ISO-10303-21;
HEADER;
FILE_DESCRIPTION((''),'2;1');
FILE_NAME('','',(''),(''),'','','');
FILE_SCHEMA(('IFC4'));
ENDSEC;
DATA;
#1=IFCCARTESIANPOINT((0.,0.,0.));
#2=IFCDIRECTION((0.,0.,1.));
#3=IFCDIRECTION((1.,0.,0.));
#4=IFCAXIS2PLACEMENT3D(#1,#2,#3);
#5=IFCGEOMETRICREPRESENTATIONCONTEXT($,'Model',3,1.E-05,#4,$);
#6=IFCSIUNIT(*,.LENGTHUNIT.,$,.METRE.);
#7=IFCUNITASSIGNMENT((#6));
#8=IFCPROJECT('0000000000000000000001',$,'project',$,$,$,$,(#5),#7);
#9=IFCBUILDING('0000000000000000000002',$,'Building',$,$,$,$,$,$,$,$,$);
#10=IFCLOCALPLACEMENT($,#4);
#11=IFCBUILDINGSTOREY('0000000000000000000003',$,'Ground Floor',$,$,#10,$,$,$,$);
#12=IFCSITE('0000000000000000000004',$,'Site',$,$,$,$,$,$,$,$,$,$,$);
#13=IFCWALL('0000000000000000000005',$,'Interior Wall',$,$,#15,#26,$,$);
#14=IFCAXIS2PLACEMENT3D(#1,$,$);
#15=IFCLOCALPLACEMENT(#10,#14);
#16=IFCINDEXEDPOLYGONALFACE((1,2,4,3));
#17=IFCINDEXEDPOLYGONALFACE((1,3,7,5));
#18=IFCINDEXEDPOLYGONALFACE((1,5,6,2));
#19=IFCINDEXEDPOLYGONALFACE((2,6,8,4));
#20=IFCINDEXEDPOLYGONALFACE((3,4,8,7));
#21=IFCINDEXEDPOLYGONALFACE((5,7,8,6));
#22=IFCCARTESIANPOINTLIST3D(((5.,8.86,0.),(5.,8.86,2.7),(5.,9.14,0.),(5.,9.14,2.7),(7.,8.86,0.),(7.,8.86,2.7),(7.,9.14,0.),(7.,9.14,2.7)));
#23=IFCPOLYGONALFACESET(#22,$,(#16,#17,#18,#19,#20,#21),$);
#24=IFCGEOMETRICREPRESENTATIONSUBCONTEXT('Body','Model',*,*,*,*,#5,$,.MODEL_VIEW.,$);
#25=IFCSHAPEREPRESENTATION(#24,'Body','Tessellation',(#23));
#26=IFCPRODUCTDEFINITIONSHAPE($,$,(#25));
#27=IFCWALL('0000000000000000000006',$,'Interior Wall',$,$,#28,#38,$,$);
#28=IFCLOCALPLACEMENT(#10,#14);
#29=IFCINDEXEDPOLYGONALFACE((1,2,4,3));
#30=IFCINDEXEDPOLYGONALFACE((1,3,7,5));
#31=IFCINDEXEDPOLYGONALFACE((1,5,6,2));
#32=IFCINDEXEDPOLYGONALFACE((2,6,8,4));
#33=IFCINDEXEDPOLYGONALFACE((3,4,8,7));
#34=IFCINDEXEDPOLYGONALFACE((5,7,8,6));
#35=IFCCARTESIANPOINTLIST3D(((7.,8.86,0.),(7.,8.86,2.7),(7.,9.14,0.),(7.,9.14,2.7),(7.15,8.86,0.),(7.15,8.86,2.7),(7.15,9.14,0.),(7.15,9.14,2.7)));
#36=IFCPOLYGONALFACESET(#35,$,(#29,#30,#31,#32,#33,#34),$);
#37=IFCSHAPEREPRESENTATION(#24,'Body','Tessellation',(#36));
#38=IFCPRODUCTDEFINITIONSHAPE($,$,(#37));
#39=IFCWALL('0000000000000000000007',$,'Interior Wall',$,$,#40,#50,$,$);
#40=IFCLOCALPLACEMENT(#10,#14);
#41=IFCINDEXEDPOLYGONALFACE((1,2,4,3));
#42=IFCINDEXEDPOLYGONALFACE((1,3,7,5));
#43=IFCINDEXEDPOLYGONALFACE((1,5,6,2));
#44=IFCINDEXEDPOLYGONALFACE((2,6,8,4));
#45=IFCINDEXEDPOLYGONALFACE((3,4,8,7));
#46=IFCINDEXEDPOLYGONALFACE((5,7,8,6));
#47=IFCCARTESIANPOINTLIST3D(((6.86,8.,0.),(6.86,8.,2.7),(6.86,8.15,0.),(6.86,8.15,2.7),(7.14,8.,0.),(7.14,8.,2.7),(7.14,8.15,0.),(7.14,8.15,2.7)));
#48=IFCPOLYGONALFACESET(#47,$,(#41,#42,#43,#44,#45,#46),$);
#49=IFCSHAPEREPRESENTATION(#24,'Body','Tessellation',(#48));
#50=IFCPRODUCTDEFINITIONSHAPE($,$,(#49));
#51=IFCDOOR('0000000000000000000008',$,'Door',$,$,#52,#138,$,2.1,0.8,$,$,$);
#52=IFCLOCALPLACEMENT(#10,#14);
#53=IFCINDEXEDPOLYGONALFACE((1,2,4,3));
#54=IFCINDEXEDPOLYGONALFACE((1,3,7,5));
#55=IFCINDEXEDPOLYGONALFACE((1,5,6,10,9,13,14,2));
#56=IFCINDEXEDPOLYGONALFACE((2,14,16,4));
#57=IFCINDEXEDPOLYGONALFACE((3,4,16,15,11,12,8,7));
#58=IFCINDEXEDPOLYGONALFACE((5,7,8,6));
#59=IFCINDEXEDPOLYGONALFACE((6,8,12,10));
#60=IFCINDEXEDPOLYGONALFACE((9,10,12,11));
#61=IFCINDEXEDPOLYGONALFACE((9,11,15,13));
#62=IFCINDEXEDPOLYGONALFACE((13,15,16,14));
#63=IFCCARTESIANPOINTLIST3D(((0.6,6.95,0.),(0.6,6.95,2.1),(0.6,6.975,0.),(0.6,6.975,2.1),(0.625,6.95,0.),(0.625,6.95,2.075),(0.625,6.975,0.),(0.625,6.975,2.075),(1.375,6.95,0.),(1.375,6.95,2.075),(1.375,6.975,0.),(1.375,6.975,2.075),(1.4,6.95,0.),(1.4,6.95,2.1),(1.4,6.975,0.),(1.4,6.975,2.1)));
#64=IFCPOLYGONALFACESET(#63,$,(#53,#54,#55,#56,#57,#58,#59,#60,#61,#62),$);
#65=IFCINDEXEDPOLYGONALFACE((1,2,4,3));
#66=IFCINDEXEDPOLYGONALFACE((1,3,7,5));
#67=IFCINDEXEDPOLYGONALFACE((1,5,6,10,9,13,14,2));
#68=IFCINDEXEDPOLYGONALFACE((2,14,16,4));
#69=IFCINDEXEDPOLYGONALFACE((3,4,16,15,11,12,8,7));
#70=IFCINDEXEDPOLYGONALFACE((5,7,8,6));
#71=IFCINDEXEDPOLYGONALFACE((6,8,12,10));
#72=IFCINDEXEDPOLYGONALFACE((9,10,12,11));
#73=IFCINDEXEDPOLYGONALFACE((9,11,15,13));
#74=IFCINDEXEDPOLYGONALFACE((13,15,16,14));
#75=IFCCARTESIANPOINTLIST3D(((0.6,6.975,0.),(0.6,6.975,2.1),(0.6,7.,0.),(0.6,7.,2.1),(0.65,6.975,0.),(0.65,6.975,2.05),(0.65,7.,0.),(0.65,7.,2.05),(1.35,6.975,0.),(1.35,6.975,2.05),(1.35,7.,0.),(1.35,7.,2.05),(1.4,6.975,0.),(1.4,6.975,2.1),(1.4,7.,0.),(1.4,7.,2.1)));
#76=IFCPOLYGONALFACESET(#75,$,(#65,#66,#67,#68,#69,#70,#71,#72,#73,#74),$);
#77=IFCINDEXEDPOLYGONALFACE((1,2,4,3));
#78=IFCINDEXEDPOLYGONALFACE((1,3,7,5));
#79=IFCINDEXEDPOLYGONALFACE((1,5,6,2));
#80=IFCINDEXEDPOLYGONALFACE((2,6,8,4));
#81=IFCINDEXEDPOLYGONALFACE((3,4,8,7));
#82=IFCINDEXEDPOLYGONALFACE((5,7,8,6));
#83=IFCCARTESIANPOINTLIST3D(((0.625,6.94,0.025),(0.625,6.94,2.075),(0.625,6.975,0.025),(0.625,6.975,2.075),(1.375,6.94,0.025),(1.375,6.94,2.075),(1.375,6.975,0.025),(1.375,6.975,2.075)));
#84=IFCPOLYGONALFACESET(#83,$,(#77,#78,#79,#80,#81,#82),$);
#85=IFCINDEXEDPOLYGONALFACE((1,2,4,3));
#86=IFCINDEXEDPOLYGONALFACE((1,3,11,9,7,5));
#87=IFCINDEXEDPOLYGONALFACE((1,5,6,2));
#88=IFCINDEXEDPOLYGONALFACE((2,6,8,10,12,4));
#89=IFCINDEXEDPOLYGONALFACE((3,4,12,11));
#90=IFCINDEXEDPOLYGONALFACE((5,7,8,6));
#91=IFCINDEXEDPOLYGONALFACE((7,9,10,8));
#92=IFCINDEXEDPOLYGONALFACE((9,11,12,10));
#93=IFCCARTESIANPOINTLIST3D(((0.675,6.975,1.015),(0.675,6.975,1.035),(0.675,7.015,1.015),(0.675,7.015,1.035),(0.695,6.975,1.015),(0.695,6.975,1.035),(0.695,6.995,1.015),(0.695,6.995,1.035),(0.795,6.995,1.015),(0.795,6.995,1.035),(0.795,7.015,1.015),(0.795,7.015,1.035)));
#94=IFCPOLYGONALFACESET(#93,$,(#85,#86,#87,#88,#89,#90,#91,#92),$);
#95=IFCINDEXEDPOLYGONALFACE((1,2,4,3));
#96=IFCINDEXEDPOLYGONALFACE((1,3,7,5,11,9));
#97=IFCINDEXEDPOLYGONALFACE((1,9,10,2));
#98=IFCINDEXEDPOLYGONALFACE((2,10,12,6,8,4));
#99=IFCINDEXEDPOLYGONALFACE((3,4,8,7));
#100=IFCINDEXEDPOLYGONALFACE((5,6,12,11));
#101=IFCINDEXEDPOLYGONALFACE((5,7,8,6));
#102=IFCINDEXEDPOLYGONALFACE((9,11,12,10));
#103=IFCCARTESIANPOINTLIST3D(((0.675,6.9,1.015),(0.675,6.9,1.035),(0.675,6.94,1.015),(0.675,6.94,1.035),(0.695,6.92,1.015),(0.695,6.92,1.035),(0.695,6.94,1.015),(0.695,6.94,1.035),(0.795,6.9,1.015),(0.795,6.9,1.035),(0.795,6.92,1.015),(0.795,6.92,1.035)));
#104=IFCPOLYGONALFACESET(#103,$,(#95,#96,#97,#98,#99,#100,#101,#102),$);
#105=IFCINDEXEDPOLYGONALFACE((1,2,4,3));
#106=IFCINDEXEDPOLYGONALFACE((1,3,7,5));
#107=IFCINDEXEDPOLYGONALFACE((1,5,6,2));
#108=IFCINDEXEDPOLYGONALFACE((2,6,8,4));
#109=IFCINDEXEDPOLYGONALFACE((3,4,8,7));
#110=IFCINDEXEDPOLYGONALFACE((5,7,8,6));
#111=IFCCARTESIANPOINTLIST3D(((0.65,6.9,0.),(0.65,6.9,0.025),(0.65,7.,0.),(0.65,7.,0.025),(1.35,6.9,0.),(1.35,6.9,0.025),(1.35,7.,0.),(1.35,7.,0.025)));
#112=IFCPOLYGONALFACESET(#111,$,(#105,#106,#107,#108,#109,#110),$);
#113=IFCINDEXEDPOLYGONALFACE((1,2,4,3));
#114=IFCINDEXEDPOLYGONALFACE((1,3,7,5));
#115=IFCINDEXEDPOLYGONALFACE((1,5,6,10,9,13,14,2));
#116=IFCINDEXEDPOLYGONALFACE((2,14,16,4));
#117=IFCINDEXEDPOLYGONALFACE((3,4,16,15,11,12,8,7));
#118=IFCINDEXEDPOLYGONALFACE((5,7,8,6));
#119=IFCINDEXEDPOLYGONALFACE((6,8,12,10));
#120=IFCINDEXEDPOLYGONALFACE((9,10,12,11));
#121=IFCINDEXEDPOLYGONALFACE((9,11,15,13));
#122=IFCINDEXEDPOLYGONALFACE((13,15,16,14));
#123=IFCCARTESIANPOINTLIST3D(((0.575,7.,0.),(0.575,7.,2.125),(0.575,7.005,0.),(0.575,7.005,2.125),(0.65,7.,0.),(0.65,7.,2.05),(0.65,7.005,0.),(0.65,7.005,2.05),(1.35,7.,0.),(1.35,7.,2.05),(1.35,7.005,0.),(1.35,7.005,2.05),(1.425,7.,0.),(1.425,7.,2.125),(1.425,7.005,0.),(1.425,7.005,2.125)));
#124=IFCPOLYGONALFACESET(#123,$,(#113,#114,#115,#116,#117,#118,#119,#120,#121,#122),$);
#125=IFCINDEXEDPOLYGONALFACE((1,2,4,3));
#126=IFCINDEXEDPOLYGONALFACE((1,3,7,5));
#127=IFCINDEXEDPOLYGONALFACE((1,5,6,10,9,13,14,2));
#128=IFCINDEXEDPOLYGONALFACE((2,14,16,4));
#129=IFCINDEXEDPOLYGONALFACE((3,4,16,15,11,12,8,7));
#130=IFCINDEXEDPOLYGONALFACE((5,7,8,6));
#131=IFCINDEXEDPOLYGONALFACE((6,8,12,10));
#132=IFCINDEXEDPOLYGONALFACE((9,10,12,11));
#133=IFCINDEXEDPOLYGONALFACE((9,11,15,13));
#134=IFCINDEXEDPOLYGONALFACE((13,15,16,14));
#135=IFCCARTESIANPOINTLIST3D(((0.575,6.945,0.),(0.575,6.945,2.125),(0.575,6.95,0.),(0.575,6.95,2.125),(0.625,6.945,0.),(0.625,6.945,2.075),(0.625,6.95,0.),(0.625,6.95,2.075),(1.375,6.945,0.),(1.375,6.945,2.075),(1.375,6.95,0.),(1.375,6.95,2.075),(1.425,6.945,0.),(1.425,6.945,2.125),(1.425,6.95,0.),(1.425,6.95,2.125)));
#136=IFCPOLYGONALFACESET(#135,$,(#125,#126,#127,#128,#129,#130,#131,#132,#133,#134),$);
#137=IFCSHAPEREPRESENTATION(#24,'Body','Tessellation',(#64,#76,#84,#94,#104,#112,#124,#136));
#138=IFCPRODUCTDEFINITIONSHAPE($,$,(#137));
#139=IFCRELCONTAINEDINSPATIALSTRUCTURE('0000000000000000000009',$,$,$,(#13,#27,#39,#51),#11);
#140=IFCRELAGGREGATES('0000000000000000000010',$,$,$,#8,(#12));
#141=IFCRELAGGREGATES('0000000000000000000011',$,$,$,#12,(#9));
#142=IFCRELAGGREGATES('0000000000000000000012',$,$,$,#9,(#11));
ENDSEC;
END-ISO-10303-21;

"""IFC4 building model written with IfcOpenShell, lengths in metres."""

from ifc_helpers import new_model, si_unit, frame, origin_with_axes, place, context, subcontext, project, spatial, line, indexed_curve, outline, extrude, element, save


model = new_model("IFC4")

# Units and contexts
model_context = context("Model", 3, precision=1e-05, world=origin_with_axes())
body_context = subcontext(model_context, "Body", "Model", "MODEL_VIEW")
ifc_project = project(units=[si_unit("LENGTHUNIT", "METRE")], contexts=[model_context])

# Site, building, storey
site = spatial("IfcSite", under=ifc_project, Name="Site")
building = spatial("IfcBuilding", under=site, Name="Building")
storey_placement = place(None, origin_with_axes())
storey = spatial("IfcBuildingStorey", under=building, at=storey_placement, Name="Ground Floor")

# Walls
wall_1_placement = place(storey_placement, frame((5.0, 9.0, 0.0), z_axis=(0.0, 0.0, 1.0), x_axis=(1.0, 0.0, 0.0)))
element("IfcWall", 1, at=wall_1_placement, inside=storey, Name="Interior Wall", context=body_context, shape_type="SweptSolid", body=[
    extrude(outline(indexed_curve([(0.0, 0.0), (0.0, 0.28), (2.0, 0.28), (2.0, 0.0), (0.0, 0.0)], self_intersect=False)), frame((0.0, -0.14, 0.0), z_axis=(0.0, 0.0, 1.0), x_axis=(1.0, 0.0, 0.0)), (0.0, 0.0, 1.0), 2.7),
])
for number, where, z_axis, x_axis, name in (
    (2, (7.0, 9.0, 0.0), (0.0, 0.0, 1.0), (1.0, 0.0, 0.0), "Interior Wall"),
    (3, (7.0, 8.0, 0.0), (0.0, 0.0, 1.0), (0.0, 1.0, 0.0), "Interior Wall"),
):
    element("IfcWall", number, at=place(storey_placement, frame(where, z_axis=z_axis, x_axis=x_axis)), inside=storey, Name=name, context=body_context, shape_type="SweptSolid", body=[
        extrude(outline(indexed_curve([(0.0, 0.0), (0.0, 0.28), (0.15, 0.28), (0.15, 0.0), (0.0, 0.0)], self_intersect=False)), frame((0.0, -0.14, 0.0), z_axis=(0.0, 0.0, 1.0), x_axis=(1.0, 0.0, 0.0)), (0.0, 0.0, 1.0), 2.7),
    ])

# Door
door_1_placement = place(storey_placement, frame((1.4, 7.0, 0.0), z_axis=(0.0, 0.0, 1.0), x_axis=(-1.0, 0.0, 0.0)))
element("IfcDoor", 4, at=door_1_placement, inside=storey, Name="Door", OverallHeight=2.1, OverallWidth=0.8, context=body_context, shape_type="SweptSolid", body=[
    extrude(outline(indexed_curve([(0.0, 0.0), (0.0, 2.1), (0.8, 2.1), (0.8, 0.0), (0.775, 0.0), (0.775, 2.075), (0.025, 2.075), (0.025, 0.0)], segments=[line(1, 2, 3, 4, 5, 6, 7, 8, 1)])), frame((0.0, 0.025, 0.0), z_axis=(0.0, -1.0, 0.0), x_axis=(1.0, 0.0, 0.0)), (0.0, 0.0, -1.0), 0.025),
    extrude(outline(indexed_curve([(0.0, 0.0), (0.0, 2.1), (0.8, 2.1), (0.8, 0.0), (0.75, 0.0), (0.75, 2.05), (0.05, 2.05), (0.05, 0.0)], segments=[line(1, 2, 3, 4, 5, 6, 7, 8, 1)])), frame((0.0, 0.0, 0.0), z_axis=(0.0, -1.0, 0.0), x_axis=(1.0, 0.0, 0.0)), (0.0, 0.0, -1.0), 0.025),
    extrude(outline(indexed_curve([(0.0, 0.0), (0.75, 0.0), (0.75, 0.035), (0.0, 0.035)], segments=[line(1, 2, 3, 4, 1)])), frame((0.025, 0.025, 0.025), z_axis=(0.0, 0.0, 1.0), x_axis=(1.0, 0.0, 0.0)), (0.0, 0.0, 1.0), 2.05),
    extrude(outline(indexed_curve([(0.0, 0.0), (0.0, -0.04), (-0.12, -0.04), (-0.12, -0.02), (-0.02, -0.02), (-0.02, 0.0)], segments=[line(1, 2, 3, 4, 5, 6, 1)])), frame((0.725, 0.025, 1.015), z_axis=(0.0, 0.0, 1.0), x_axis=(1.0, 0.0, 0.0)), (0.0, 0.0, 1.0), 0.02),
    extrude(outline(indexed_curve([(0.0, 0.0), (0.0, 0.04), (-0.12, 0.04), (-0.12, 0.02), (-0.02, 0.02), (-0.02, 0.0)], segments=[line(1, 2, 3, 4, 5, 6, 1)])), frame((0.725, 0.06, 1.015), z_axis=(0.0, 0.0, 1.0), x_axis=(1.0, 0.0, 0.0)), (0.0, 0.0, 1.0), 0.02),
    extrude(outline(indexed_curve([(0.0, 0.0), (0.7, 0.0), (0.7, 0.1), (0.0, 0.1)], segments=[line(1, 2, 3, 4, 1)])), frame((0.05, 0.0, 0.0), z_axis=(0.0, 0.0, 1.0), x_axis=(1.0, 0.0, 0.0)), (0.0, 0.0, 1.0), 0.025),
    extrude(outline(indexed_curve([(0.0, 0.0), (0.0, 2.125), (0.85, 2.125), (0.85, 0.0), (0.775, 0.0), (0.775, 2.05), (0.075, 2.05), (0.075, 0.0)], segments=[line(1, 2, 3, 4, 5, 6, 7, 8, 1)])), frame((-0.025, -0.005, 0.0), z_axis=(0.0, -1.0, 0.0), x_axis=(1.0, 0.0, 0.0)), (0.0, 0.0, -1.0), 0.005),
    extrude(outline(indexed_curve([(0.0, 0.0), (0.0, 2.125), (0.85, 2.125), (0.85, 0.0), (0.8, 0.0), (0.8, 2.075), (0.05, 2.075), (0.05, 0.0)], segments=[line(1, 2, 3, 4, 5, 6, 7, 8, 1)])), frame((-0.025, 0.05, 0.0), z_axis=(0.0, -1.0, 0.0), x_axis=(1.0, 0.0, 0.0)), (0.0, 0.0, -1.0), 0.005),
])

save(model, "model.ifc")
